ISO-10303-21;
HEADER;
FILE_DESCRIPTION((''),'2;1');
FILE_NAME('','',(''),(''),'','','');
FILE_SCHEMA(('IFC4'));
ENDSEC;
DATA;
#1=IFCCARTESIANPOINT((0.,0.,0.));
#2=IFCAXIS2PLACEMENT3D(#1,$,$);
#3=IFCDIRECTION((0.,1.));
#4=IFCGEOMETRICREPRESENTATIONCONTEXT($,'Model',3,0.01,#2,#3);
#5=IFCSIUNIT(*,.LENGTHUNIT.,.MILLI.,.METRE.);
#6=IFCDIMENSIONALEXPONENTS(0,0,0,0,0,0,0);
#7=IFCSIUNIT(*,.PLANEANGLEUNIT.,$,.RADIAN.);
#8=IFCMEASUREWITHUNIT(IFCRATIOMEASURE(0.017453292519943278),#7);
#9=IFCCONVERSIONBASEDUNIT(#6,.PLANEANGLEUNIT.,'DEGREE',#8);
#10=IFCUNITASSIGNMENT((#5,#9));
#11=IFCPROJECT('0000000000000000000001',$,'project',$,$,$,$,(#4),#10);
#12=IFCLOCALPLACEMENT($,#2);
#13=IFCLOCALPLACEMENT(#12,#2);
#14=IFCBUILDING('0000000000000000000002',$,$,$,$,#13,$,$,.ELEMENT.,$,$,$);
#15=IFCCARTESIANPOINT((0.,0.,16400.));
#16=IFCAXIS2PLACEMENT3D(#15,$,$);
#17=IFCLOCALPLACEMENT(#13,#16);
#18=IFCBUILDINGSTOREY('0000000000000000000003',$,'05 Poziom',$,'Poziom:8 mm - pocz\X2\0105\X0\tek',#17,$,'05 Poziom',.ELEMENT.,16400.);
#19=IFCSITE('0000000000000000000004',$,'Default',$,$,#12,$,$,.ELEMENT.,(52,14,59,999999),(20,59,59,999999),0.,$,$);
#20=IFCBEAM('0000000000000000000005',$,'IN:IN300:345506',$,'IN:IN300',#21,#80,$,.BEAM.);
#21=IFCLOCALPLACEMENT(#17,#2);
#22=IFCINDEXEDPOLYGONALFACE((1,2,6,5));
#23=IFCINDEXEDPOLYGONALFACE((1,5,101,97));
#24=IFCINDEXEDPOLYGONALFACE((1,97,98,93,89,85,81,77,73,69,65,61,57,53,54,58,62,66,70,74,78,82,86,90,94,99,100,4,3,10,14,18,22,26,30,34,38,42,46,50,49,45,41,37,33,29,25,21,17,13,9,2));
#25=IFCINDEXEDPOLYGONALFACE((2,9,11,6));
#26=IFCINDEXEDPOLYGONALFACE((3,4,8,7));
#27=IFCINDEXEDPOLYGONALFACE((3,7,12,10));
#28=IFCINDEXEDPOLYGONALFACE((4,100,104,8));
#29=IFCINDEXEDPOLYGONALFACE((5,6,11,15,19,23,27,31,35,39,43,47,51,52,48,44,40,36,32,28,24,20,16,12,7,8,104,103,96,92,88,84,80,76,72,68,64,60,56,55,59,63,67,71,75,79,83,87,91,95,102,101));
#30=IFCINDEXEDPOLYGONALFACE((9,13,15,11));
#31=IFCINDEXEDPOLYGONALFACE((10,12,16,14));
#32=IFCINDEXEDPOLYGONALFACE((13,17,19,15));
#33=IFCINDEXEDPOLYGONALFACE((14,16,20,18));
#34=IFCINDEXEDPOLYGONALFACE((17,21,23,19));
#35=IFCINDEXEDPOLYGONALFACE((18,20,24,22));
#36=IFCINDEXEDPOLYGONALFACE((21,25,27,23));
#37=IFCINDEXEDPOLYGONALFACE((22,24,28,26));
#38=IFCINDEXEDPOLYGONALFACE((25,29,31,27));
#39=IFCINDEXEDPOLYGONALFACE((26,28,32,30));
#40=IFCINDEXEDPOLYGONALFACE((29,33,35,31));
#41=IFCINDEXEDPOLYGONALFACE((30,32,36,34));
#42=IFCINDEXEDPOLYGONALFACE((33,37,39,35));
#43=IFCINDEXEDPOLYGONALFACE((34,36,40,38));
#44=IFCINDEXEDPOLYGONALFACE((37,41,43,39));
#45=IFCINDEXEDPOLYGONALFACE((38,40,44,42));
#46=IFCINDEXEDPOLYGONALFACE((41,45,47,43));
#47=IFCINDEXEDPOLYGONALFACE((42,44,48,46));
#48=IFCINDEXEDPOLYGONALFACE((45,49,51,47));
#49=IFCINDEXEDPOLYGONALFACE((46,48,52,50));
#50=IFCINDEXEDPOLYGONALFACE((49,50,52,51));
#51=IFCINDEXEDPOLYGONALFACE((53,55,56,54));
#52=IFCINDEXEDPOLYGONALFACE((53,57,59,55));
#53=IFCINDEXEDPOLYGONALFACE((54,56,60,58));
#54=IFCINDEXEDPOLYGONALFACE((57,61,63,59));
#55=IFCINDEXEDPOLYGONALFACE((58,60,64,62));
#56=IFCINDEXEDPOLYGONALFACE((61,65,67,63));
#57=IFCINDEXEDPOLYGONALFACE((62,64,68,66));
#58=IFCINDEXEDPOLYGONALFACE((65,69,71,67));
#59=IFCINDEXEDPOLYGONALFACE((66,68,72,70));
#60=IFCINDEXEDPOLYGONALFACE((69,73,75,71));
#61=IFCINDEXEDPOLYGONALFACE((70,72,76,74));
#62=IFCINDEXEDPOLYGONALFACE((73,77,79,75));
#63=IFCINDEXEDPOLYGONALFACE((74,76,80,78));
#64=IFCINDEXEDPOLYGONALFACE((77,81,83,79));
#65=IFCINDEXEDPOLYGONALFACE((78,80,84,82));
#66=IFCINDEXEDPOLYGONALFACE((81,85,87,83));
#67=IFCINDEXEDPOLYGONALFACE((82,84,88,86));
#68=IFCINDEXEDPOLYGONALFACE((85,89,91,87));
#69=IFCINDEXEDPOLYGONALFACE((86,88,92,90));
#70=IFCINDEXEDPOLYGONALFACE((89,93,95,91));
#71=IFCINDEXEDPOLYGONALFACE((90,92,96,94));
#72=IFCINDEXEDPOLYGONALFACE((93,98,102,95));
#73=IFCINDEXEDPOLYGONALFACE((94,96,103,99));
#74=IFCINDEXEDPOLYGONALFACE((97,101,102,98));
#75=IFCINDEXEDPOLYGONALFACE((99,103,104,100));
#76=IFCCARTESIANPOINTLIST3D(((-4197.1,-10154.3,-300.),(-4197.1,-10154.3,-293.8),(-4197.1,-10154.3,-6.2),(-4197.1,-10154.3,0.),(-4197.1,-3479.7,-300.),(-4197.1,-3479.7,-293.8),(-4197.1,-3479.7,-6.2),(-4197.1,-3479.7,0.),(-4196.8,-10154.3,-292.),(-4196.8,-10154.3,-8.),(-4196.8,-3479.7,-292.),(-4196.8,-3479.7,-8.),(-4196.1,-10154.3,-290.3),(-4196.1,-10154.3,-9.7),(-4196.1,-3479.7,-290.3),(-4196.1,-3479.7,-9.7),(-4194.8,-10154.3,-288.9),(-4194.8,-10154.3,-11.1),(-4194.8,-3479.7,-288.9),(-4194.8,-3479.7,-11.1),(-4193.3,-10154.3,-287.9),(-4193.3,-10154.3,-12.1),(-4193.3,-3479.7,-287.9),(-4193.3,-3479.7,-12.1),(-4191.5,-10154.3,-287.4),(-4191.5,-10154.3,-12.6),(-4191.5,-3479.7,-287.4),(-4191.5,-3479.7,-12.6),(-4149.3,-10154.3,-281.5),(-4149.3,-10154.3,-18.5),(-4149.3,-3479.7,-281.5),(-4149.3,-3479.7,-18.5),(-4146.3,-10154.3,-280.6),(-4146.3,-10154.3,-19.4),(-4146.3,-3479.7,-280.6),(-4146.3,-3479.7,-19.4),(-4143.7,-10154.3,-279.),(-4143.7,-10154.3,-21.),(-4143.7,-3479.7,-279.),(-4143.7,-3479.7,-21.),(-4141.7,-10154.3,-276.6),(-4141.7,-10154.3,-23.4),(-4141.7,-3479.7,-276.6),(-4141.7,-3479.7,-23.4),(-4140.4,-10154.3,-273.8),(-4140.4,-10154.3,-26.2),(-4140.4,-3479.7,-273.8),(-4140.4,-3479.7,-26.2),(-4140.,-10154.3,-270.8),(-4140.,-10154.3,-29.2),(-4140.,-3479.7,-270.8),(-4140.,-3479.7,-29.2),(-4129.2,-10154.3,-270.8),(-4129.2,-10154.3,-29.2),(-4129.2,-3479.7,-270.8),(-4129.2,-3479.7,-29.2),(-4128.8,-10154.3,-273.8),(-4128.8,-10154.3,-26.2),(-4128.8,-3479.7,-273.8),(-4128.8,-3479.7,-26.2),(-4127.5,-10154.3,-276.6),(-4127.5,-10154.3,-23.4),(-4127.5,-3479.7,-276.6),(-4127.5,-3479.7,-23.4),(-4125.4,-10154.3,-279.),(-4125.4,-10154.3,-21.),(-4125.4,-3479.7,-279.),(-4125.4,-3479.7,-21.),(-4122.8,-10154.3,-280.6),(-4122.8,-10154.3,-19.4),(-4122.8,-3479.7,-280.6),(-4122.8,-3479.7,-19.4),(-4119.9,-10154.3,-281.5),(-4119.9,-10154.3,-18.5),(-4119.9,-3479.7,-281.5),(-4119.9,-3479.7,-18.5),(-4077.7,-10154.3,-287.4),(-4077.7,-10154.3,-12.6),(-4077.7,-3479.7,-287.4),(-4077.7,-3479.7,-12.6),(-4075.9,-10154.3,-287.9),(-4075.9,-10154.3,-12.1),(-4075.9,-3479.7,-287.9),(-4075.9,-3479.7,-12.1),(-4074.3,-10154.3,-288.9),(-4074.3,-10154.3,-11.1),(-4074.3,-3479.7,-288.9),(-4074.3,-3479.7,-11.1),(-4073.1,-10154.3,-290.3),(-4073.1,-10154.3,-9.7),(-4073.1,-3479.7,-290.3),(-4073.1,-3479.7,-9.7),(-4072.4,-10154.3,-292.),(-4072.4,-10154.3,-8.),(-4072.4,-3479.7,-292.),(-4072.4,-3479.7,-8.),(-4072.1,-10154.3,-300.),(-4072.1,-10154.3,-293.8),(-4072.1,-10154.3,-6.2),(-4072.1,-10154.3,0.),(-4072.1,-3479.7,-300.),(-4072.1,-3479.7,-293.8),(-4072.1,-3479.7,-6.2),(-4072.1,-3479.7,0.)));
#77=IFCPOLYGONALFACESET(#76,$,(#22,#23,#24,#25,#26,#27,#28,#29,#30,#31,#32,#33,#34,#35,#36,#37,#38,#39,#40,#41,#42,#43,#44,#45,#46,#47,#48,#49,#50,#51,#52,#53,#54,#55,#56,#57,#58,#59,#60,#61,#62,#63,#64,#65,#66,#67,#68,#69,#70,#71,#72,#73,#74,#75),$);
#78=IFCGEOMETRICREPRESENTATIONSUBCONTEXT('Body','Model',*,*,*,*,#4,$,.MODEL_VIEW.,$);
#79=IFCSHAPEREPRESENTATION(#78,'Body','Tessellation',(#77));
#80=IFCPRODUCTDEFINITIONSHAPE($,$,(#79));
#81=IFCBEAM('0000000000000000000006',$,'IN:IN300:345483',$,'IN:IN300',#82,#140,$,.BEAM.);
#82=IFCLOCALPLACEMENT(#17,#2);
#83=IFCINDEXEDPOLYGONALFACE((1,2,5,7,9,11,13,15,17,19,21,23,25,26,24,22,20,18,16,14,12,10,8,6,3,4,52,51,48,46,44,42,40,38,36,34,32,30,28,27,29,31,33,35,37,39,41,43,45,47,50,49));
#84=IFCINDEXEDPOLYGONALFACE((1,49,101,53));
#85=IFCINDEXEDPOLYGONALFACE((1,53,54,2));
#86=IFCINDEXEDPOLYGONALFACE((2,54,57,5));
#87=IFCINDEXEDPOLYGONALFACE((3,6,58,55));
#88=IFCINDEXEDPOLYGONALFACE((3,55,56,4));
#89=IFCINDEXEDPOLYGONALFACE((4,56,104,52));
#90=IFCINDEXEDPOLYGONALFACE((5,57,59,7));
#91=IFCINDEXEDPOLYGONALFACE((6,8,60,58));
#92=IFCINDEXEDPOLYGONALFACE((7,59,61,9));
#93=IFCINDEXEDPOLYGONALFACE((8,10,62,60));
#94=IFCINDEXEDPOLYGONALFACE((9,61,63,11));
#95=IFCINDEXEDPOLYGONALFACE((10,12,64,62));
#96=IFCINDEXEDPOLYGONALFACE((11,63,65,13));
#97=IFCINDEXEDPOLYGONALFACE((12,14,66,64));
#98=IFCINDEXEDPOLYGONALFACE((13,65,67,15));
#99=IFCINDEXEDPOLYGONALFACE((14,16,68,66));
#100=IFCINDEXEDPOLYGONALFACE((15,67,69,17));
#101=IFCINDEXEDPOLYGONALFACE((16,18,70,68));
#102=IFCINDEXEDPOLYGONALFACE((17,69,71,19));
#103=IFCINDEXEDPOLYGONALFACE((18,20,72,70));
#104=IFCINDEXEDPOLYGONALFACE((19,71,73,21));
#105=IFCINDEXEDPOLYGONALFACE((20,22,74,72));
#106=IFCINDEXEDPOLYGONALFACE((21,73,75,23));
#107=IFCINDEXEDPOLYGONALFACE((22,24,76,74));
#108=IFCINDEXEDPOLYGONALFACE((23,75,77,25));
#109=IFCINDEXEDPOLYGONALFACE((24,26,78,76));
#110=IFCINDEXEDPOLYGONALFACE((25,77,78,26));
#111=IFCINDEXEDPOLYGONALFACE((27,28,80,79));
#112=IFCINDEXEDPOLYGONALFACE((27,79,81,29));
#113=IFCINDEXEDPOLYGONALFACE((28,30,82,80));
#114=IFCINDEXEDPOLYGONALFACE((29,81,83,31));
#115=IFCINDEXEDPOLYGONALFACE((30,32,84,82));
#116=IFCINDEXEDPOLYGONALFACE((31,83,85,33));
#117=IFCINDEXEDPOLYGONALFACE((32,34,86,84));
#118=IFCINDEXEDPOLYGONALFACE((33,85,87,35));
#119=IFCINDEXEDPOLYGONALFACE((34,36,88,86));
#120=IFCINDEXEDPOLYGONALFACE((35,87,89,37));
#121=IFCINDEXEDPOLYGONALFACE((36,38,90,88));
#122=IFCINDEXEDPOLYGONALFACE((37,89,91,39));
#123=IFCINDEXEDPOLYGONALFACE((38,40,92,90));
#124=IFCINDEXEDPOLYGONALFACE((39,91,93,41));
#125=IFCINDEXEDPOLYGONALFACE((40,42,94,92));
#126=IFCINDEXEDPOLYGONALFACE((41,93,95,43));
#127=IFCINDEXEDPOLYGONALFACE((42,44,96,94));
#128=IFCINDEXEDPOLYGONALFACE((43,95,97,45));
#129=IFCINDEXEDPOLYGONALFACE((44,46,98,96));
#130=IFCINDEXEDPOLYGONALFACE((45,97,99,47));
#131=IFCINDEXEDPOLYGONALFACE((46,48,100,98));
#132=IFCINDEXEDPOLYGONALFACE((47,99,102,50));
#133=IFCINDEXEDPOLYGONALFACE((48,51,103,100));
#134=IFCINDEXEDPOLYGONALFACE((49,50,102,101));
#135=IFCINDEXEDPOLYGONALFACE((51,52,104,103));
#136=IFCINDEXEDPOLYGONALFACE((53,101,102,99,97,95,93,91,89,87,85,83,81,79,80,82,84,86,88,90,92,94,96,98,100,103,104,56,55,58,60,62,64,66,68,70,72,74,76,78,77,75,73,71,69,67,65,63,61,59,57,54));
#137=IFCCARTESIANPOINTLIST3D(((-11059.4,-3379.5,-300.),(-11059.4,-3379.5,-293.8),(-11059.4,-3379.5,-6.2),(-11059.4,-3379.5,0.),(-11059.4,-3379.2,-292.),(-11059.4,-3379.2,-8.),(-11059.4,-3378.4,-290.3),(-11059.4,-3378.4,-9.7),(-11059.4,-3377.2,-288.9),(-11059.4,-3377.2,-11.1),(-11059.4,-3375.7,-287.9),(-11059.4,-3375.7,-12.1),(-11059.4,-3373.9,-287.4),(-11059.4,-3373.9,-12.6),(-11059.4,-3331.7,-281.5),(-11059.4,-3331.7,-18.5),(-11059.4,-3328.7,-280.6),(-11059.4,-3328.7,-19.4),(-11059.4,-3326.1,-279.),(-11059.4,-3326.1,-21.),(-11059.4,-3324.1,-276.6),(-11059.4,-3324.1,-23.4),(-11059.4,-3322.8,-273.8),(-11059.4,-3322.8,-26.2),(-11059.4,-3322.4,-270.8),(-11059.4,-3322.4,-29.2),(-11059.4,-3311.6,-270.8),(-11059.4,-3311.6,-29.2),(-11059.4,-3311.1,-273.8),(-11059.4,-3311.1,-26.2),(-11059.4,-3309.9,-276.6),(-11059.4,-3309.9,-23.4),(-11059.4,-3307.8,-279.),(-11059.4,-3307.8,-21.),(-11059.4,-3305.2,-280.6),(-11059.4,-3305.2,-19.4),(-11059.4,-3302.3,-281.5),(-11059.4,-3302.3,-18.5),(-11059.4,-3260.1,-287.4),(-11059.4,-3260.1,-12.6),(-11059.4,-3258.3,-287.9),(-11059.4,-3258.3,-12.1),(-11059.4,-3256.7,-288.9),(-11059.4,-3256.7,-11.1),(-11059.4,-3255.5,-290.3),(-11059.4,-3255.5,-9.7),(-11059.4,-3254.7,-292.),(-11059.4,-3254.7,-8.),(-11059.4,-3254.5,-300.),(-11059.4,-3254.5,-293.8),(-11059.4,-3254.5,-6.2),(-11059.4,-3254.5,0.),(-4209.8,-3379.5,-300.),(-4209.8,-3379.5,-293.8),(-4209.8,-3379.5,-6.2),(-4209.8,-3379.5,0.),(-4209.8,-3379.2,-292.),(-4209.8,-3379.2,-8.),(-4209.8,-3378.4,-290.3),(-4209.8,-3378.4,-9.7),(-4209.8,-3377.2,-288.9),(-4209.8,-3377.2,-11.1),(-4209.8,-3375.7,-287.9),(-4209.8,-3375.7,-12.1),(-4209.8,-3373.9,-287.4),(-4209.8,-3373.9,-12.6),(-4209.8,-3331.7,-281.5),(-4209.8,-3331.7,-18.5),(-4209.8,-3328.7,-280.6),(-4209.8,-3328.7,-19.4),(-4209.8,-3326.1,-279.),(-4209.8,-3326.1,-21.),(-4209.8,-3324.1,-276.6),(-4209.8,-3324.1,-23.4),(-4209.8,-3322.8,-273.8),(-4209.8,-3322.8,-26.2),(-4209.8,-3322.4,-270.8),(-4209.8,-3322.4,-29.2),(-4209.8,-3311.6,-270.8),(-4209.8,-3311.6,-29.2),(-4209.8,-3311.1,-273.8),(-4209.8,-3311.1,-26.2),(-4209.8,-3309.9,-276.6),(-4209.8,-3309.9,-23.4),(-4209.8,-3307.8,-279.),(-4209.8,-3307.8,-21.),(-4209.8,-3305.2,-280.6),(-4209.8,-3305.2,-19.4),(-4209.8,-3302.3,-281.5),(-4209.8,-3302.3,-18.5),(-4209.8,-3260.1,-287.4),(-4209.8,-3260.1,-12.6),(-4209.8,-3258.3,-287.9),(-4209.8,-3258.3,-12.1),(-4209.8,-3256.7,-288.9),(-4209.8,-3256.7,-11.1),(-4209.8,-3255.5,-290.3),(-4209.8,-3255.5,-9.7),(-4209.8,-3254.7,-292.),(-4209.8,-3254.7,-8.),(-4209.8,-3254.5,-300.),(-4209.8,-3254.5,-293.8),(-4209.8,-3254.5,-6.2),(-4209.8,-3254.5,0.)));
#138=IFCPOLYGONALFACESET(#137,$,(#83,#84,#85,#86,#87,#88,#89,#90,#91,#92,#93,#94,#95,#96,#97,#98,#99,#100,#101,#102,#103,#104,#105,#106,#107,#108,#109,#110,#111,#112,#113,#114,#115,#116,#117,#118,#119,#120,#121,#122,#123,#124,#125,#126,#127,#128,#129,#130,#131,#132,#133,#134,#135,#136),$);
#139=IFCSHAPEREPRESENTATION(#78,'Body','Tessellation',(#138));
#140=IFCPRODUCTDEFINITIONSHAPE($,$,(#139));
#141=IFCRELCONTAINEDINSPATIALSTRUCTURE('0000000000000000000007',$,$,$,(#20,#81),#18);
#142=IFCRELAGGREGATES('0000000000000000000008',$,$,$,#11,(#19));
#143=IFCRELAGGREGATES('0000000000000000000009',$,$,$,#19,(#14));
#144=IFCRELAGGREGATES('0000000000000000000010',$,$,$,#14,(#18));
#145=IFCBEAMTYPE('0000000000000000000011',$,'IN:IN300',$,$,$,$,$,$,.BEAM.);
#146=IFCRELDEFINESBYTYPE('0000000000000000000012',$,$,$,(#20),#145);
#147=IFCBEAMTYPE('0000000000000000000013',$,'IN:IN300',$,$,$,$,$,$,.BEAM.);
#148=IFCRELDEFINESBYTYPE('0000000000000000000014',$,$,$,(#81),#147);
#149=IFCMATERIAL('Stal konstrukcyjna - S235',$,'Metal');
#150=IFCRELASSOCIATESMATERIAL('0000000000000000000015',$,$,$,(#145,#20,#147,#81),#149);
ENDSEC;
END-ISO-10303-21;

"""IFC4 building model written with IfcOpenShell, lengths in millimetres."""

from ifc_helpers import new_model, entity, si_unit, converted_unit, direction, frame, origin, place, context, subcontext, project, spatial, line, arc, indexed_curve, outline, extrude, source, transform, mapped, material, type_object, type_shapes, element, save


model = new_model("IFC4")

# Units and contexts
model_context = context("Model", 3, precision=0.01, world=origin(), true_north=direction((0.0, 1.0)))
body_context = subcontext(model_context, "Body", "Model", "MODEL_VIEW")
ifc_project = project(units=[si_unit("LENGTHUNIT", "METRE", prefix="MILLI"), converted_unit("PLANEANGLEUNIT", "DEGREE", entity("IfcRatioMeasure", 0.017453292519943278), si_unit("PLANEANGLEUNIT", "RADIAN"), dimensions=[0, 0, 0, 0, 0, 0, 0])], contexts=[model_context])

# Site, building, storey
site_placement = place(None, origin())
site = spatial("IfcSite", under=ifc_project, at=site_placement, Name="Default", CompositionType="ELEMENT", RefLatitude=(52, 14, 59, 999999), RefLongitude=(20, 59, 59, 999999), RefElevation=0.0)
building_placement = place(site_placement, origin())
building = spatial("IfcBuilding", under=site, at=building_placement, CompositionType="ELEMENT")
storey_placement = place(building_placement, frame((0.0, 0.0, 16400.0)))
storey = spatial("IfcBuildingStorey", under=building, at=storey_placement, Name="05 Poziom", ObjectType="Poziom:8 mm - początek", LongName="05 Poziom", CompositionType="ELEMENT", Elevation=16400.0)

# Shared definitions
ifc_material = material(Name="Stal konstrukcyjna - S235", Category="Metal")

# Beams
beam_type_1 = type_object("IfcBeamType", Name="IN:IN300", PredefinedType="BEAM", material=ifc_material)
shared_shape_1 = source(origin(), body_context, "Body", "SweptSolid", [
    extrude(outline(indexed_curve([(143.8, -62.5), (150.0, -62.5), (150.0, 62.5), (143.8, 62.5), (139.6, 60.9), (137.4, 56.9), (131.5, 14.7), (127.9, 8.1), (120.8, 5.4), (-120.8, 5.4), (-127.9, 8.1), (-131.5, 14.7), (-137.4, 56.9), (-139.6, 60.9), (-143.8, 62.5), (-150.0, 62.5), (-150.0, -62.5), (-143.8, -62.5), (-139.6, -60.9), (-137.4, -56.9), (-131.5, -14.7), (-127.9, -8.1), (-120.8, -5.4), (120.8, -5.4), (127.9, -8.1), (131.5, -14.7), (137.4, -56.9), (139.6, -60.9)], segments=[line(1, 2, 3, 4), arc(4, 5, 6), line(6, 7), arc(7, 8, 9), line(9, 10), arc(10, 11, 12), line(12, 13), arc(13, 14, 15), line(15, 16, 17, 18), arc(18, 19, 20), line(20, 21), arc(21, 22, 23), line(23, 24), arc(24, 25, 26), line(26, 27), arc(27, 28, 1)], self_intersect=False)), frame((-3337.3, 0.0, 0.0), z_axis=(1.0, 0.0, 0.0), x_axis=(0.0, 0.0, -1.0)), (0.0, 0.0, 1.0), 6674.6),
])
type_shapes(beam_type_1, [shared_shape_1])
for number, where, z_axis, x_axis, name in (
    (1, (-4134.6, -6817.0, -150.0), (0.0, 0.0, 1.0), (0.0, -1.0, 0.0), "IN:IN300:345506"),
):
    element("IfcBeam", number, at=place(storey_placement, frame(where, z_axis=z_axis, x_axis=x_axis)), inside=storey, type_object=beam_type_1, material=ifc_material, Name=name, ObjectType="IN:IN300", PredefinedType="BEAM", context=body_context, shape_type="MappedRepresentation", body=[
        mapped(shared_shape_1, transform((0.0, 0.0, 0.0), scale=1.0)),
    ])
beam_type_2 = type_object("IfcBeamType", Name="IN:IN300", PredefinedType="BEAM", material=ifc_material)
shared_shape_2 = source(origin(), body_context, "Body", "SweptSolid", [
    extrude(outline(indexed_curve([(143.8, -62.5), (150.0, -62.5), (150.0, 62.5), (143.8, 62.5), (139.6, 60.9), (137.4, 56.9), (131.5, 14.7), (127.9, 8.1), (120.8, 5.4), (-120.8, 5.4), (-127.9, 8.1), (-131.5, 14.7), (-137.4, 56.9), (-139.6, 60.9), (-143.8, 62.5), (-150.0, 62.5), (-150.0, -62.5), (-143.8, -62.5), (-139.6, -60.9), (-137.4, -56.9), (-131.5, -14.7), (-127.9, -8.1), (-120.8, -5.4), (120.8, -5.4), (127.9, -8.1), (131.5, -14.7), (137.4, -56.9), (139.6, -60.9)], segments=[line(1, 2, 3, 4), arc(4, 5, 6), line(6, 7), arc(7, 8, 9), line(9, 10), arc(10, 11, 12), line(12, 13), arc(13, 14, 15), line(15, 16, 17, 18), arc(18, 19, 20), line(20, 21), arc(21, 22, 23), line(23, 24), arc(24, 25, 26), line(26, 27), arc(27, 28, 1)], self_intersect=False)), frame((-3424.8, 0.0, 0.0), z_axis=(1.0, 0.0, 0.0), x_axis=(0.0, 0.0, -1.0)), (0.0, 0.0, 1.0), 6849.6),
])
type_shapes(beam_type_2, [shared_shape_2])
for number, where, name in (
    (2, (-7634.6, -3317.0, -150.0), "IN:IN300:345483"),
):
    element("IfcBeam", number, at=place(storey_placement, frame(where)), inside=storey, type_object=beam_type_2, material=ifc_material, Name=name, ObjectType="IN:IN300", PredefinedType="BEAM", context=body_context, shape_type="MappedRepresentation", body=[
        mapped(shared_shape_2, transform((0.0, 0.0, 0.0), scale=1.0)),
    ])

save(model, "model.ifc")
